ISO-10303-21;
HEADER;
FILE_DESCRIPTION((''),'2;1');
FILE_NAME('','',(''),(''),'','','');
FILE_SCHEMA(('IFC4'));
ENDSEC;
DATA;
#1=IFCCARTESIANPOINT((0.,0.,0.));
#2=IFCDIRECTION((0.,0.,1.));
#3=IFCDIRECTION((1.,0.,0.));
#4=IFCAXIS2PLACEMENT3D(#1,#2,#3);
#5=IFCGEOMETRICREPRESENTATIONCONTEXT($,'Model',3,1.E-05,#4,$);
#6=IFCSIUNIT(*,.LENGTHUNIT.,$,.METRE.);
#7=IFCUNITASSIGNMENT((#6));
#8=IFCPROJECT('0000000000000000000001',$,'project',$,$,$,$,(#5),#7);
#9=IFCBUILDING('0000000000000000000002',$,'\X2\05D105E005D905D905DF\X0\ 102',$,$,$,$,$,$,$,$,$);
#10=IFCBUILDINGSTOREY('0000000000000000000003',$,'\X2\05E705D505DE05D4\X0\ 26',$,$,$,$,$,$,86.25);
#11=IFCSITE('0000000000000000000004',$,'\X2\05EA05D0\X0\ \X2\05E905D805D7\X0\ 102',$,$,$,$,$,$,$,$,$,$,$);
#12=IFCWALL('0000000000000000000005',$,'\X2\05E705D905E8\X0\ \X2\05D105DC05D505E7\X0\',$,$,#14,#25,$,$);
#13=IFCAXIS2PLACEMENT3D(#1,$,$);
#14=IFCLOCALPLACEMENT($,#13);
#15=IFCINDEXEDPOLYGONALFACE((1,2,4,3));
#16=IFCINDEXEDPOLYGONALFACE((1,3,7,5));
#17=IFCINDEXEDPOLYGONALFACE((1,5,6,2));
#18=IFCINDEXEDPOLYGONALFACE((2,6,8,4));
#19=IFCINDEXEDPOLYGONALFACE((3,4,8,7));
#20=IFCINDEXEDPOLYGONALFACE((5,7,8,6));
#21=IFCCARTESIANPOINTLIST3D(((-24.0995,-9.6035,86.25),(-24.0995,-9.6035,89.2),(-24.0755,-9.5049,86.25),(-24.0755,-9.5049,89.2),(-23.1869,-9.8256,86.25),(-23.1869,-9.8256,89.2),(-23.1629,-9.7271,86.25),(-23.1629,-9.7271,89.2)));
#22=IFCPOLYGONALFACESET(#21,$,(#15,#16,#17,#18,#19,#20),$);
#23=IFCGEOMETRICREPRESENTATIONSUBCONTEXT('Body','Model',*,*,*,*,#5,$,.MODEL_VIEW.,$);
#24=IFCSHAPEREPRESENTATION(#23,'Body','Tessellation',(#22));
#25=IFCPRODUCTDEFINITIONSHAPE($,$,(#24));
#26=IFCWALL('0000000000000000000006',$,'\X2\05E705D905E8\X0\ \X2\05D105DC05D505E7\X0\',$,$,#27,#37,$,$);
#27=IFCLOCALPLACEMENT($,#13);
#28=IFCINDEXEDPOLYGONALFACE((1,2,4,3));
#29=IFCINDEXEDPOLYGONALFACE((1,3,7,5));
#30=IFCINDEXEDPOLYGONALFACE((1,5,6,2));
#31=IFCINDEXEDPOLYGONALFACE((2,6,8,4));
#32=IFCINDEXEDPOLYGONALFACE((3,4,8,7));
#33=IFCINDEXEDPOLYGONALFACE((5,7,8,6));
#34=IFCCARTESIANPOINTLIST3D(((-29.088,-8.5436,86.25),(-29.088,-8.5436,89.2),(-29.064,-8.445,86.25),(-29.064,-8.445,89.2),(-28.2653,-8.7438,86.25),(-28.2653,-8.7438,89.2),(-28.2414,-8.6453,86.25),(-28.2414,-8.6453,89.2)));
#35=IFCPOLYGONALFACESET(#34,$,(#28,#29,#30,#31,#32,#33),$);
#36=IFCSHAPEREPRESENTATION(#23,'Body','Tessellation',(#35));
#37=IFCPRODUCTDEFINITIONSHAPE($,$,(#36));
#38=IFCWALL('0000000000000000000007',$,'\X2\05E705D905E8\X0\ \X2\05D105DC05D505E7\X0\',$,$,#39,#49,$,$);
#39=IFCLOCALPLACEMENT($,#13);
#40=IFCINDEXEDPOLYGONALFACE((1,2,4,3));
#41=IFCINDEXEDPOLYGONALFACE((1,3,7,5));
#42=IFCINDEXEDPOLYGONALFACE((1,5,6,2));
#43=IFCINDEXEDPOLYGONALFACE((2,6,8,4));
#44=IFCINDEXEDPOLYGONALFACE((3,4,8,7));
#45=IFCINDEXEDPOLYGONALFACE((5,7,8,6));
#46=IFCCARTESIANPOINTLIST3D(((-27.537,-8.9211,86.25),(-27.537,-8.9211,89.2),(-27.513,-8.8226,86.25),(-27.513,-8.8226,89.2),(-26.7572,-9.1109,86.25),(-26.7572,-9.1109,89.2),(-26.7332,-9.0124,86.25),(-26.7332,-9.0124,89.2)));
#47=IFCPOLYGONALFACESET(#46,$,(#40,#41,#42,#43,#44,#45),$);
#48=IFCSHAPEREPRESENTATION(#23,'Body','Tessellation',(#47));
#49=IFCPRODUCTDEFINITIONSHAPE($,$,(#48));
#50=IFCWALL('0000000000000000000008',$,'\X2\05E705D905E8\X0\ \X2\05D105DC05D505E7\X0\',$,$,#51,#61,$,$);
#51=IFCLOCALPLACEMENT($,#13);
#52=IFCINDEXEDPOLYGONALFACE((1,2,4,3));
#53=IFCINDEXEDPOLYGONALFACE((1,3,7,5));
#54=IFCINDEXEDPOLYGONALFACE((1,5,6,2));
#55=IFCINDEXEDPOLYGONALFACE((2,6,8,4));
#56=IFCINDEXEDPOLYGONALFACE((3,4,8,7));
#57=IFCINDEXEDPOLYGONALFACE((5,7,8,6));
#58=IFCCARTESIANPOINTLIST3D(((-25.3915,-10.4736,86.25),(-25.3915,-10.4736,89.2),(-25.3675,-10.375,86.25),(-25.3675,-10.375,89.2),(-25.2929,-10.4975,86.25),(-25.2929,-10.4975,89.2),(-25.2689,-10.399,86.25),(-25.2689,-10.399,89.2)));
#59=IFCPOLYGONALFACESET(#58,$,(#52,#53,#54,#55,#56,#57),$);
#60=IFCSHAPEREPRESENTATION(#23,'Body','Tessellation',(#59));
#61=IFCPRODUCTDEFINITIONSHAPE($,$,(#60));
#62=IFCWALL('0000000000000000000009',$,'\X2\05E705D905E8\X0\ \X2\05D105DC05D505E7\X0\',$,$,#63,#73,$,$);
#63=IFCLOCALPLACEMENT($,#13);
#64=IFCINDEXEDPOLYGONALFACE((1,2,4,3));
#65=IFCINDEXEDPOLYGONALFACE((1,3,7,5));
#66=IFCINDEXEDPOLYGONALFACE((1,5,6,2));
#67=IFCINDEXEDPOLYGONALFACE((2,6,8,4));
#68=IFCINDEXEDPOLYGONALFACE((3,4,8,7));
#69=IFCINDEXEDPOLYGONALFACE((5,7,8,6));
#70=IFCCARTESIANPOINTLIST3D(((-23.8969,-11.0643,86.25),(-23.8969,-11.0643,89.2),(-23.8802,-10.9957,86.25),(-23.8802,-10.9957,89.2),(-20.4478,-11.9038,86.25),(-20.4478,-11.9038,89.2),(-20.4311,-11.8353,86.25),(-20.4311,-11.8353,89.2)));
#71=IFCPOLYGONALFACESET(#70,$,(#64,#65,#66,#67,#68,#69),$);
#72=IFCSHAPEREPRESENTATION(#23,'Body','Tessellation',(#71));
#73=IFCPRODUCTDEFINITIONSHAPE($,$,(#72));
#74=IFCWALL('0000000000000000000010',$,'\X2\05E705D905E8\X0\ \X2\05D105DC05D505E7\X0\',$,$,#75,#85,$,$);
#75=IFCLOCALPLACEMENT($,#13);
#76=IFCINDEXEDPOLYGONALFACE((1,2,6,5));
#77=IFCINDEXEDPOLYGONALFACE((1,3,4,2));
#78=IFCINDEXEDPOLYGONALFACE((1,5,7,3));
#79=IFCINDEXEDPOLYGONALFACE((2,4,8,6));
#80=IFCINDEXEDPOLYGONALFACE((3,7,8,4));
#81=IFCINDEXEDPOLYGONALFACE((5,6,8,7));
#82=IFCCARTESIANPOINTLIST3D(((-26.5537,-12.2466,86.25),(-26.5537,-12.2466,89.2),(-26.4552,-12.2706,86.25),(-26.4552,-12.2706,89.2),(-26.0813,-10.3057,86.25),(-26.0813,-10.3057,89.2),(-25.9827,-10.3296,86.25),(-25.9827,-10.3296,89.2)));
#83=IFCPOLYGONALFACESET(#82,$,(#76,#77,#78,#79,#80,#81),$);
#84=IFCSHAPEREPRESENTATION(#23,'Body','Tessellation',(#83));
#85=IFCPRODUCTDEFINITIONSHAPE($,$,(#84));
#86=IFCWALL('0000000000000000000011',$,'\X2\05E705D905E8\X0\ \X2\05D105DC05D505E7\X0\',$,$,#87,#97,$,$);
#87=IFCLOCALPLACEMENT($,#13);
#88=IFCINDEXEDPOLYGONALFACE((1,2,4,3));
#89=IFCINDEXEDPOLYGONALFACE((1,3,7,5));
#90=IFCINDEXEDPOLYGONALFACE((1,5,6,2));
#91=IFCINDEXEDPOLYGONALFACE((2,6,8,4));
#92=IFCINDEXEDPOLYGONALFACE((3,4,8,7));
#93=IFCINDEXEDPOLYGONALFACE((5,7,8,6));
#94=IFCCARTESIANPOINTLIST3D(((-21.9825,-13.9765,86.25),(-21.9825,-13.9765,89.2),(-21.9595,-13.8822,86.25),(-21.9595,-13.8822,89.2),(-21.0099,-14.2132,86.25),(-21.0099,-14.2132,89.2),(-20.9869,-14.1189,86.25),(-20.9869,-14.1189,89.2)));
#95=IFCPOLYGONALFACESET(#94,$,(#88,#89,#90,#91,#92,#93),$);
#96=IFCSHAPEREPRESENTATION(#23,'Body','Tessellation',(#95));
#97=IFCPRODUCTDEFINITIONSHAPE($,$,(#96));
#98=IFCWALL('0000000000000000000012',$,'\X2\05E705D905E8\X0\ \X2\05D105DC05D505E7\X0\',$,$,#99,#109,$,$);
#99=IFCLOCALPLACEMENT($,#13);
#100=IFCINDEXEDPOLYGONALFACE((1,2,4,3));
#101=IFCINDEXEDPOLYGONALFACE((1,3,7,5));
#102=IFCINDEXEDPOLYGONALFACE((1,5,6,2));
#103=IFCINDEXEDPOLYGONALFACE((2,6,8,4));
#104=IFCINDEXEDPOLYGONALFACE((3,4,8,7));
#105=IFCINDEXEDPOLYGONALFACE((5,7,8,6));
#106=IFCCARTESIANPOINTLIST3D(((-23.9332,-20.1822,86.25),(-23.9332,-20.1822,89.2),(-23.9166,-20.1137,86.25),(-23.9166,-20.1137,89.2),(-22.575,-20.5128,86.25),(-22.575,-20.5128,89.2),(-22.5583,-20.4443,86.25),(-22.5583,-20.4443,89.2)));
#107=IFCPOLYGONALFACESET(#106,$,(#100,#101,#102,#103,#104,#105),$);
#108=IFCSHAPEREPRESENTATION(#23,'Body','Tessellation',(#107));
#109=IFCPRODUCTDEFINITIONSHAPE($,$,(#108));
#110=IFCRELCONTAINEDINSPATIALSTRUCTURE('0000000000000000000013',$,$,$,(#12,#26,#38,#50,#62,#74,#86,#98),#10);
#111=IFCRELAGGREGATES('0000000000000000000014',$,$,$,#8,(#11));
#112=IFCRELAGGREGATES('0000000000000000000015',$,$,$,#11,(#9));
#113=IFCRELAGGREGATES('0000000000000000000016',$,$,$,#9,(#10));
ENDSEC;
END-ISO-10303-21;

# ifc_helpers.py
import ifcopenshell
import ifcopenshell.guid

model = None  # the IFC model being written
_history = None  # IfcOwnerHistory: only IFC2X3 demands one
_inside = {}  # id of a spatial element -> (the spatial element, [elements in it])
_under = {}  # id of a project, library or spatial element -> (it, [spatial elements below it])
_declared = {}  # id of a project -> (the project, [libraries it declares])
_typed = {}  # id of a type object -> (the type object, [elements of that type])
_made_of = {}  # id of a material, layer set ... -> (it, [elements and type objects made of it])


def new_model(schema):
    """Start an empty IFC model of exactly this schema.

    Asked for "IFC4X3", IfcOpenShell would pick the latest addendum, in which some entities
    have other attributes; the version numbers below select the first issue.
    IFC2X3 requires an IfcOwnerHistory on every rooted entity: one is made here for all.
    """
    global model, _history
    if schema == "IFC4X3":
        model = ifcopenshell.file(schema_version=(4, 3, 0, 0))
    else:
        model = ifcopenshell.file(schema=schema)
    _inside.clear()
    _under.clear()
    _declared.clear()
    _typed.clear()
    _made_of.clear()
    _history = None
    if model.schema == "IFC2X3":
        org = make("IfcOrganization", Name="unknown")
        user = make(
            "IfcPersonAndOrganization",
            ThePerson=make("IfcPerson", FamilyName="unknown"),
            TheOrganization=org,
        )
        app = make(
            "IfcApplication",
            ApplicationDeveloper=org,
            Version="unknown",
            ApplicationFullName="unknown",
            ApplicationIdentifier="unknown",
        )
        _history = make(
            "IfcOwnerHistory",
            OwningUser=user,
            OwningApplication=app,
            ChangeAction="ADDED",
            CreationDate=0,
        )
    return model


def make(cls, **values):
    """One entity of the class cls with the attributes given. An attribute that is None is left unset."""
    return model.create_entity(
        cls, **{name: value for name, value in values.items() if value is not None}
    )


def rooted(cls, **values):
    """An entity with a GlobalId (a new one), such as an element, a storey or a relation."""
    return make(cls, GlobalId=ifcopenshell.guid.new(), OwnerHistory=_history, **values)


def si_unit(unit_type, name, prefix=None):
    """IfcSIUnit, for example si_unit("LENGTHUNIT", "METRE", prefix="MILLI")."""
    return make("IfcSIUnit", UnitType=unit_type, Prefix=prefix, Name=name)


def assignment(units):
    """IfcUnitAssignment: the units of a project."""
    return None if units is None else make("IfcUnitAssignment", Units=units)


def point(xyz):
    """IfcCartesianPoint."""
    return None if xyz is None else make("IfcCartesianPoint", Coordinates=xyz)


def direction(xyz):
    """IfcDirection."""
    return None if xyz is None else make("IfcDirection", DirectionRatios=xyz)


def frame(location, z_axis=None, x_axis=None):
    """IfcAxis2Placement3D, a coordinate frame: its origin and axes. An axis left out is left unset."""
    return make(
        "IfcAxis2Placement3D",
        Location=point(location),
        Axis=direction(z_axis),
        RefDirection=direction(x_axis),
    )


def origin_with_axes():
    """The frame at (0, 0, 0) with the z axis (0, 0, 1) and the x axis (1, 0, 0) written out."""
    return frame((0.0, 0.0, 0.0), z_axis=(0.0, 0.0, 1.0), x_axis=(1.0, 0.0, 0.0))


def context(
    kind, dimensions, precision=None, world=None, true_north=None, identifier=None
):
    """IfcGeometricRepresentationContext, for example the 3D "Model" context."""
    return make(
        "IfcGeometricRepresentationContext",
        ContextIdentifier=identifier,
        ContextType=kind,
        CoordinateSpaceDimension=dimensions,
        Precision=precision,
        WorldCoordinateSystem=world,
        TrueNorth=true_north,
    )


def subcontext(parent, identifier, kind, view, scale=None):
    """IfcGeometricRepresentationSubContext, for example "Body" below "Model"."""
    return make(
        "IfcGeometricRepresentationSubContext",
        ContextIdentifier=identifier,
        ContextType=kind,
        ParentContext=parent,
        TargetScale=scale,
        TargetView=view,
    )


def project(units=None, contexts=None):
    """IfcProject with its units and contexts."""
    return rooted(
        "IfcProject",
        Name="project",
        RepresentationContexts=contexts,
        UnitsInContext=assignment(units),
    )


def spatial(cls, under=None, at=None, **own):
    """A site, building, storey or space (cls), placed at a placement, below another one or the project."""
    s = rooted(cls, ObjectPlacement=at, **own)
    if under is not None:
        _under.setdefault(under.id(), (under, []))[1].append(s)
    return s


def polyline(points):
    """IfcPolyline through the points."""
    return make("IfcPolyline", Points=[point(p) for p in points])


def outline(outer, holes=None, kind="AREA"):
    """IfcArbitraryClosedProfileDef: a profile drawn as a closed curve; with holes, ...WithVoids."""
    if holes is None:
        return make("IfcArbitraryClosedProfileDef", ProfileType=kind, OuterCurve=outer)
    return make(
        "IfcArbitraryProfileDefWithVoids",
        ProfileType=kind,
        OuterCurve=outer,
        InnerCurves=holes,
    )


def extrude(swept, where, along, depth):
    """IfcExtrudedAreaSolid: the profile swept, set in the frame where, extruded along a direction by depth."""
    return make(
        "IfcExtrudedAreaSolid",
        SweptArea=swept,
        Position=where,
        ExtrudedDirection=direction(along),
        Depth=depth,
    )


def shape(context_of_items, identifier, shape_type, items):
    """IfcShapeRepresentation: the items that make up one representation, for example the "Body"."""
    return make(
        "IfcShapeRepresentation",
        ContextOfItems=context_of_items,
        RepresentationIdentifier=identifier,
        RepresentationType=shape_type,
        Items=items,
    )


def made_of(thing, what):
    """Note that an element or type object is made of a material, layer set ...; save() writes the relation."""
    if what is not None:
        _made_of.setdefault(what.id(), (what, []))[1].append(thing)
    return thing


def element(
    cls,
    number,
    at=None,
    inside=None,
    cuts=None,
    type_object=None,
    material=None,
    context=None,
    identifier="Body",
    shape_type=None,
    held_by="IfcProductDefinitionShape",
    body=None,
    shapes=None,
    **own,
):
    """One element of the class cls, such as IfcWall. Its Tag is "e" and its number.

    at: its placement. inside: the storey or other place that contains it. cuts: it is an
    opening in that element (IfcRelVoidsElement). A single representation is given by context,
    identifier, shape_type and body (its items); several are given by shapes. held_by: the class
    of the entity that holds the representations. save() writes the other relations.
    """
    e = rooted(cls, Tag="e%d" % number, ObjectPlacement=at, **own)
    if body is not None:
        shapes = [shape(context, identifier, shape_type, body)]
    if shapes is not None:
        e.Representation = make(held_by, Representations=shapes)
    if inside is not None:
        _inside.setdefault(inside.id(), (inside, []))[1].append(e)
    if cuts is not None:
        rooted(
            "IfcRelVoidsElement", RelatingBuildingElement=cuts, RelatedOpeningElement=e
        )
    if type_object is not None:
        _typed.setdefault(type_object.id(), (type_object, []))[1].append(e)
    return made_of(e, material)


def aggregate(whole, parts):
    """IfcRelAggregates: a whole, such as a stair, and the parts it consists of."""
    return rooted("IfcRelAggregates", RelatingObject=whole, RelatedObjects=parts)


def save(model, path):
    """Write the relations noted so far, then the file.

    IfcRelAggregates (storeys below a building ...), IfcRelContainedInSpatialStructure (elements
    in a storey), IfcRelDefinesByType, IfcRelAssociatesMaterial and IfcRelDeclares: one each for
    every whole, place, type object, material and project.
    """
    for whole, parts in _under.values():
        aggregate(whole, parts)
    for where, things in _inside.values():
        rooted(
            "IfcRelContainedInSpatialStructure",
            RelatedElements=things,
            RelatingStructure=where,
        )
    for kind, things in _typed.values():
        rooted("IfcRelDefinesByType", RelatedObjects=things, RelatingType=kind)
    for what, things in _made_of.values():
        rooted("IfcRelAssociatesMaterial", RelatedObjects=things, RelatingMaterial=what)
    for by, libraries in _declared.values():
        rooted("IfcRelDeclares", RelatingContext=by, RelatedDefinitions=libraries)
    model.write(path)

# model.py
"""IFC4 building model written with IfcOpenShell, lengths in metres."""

from ifc_helpers import new_model, si_unit, frame, origin_with_axes, context, subcontext, project, spatial, polyline, outline, extrude, element, save


model = new_model("IFC4")

# Units and contexts
model_context = context("Model", 3, precision=1e-05, world=origin_with_axes())
body_context = subcontext(model_context, "Body", "Model", "MODEL_VIEW")
ifc_project = project(units=[si_unit("LENGTHUNIT", "METRE")], contexts=[model_context])

# Site, building, storey
site = spatial("IfcSite", under=ifc_project, Name="תא שטח 102")
building = spatial("IfcBuilding", under=site, Name="בניין 102")
storey = spatial("IfcBuildingStorey", under=building, Name="קומה 26", Elevation=86.25)

# Walls
element("IfcWall", 1, inside=storey, Name="קיר בלוק", context=body_context, shape_type="SweptSolid", body=[
    extrude(outline(polyline([(-24.0755, -9.5049), (-24.0995, -9.6035), (-23.1869, -9.8256), (-23.1629, -9.7271), (-24.0755, -9.5049)])), frame((0.0, 0.0, 86.25)), (0.0, 0.0, 1.0), 2.95),
])
element("IfcWall", 2, inside=storey, Name="קיר בלוק", context=body_context, shape_type="SweptSolid", body=[
    extrude(outline(polyline([(-29.088, -8.5436), (-28.2653, -8.7438), (-28.2414, -8.6453), (-29.064, -8.445), (-29.088, -8.5436)])), frame((0.0, 0.0, 86.25)), (0.0, 0.0, 1.0), 2.95),
])
element("IfcWall", 3, inside=storey, Name="קיר בלוק", context=body_context, shape_type="SweptSolid", body=[
    extrude(outline(polyline([(-27.513, -8.8226), (-27.537, -8.9211), (-26.7572, -9.1109), (-26.7332, -9.0124), (-27.513, -8.8226)])), frame((0.0, 0.0, 86.25)), (0.0, 0.0, 1.0), 2.95),
])
element("IfcWall", 4, inside=storey, Name="קיר בלוק", context=body_context, shape_type="SweptSolid", body=[
    extrude(outline(polyline([(-25.3915, -10.4736), (-25.2929, -10.4975), (-25.2689, -10.399), (-25.3675, -10.375), (-25.3915, -10.4736)])), frame((0.0, 0.0, 86.25)), (0.0, 0.0, 1.0), 2.95),
])
element("IfcWall", 5, inside=storey, Name="קיר בלוק", context=body_context, shape_type="SweptSolid", body=[
    extrude(outline(polyline([(-20.4478, -11.9038), (-20.4311, -11.8353), (-23.8802, -10.9957), (-23.8969, -11.0643), (-20.4478, -11.9038)])), frame((0.0, 0.0, 86.25)), (0.0, 0.0, 1.0), 2.95),
])
element("IfcWall", 6, inside=storey, Name="קיר בלוק", context=body_context, shape_type="SweptSolid", body=[
    extrude(outline(polyline([(-26.5537, -12.2466), (-26.4552, -12.2706), (-25.9827, -10.3296), (-26.0813, -10.3057), (-26.5537, -12.2466)])), frame((0.0, 0.0, 86.25)), (0.0, 0.0, 1.0), 2.95),
])
element("IfcWall", 7, inside=storey, Name="קיר בלוק", context=body_context, shape_type="SweptSolid", body=[
    extrude(outline(polyline([(-21.9595, -13.8822), (-21.9825, -13.9765), (-21.0099, -14.2132), (-20.9869, -14.1189), (-21.9595, -13.8822)])), frame((0.0, 0.0, 86.25)), (0.0, 0.0, 1.0), 2.95),
])
element("IfcWall", 8, inside=storey, Name="קיר בלוק", context=body_context, shape_type="SweptSolid", body=[
    extrude(outline(polyline([(-22.5583, -20.4443), (-23.9166, -20.1137), (-23.9332, -20.1822), (-22.575, -20.5128), (-22.5583, -20.4443)])), frame((0.0, 0.0, 86.25)), (0.0, 0.0, 1.0), 2.95),
])

save(model, "model.ifc")
